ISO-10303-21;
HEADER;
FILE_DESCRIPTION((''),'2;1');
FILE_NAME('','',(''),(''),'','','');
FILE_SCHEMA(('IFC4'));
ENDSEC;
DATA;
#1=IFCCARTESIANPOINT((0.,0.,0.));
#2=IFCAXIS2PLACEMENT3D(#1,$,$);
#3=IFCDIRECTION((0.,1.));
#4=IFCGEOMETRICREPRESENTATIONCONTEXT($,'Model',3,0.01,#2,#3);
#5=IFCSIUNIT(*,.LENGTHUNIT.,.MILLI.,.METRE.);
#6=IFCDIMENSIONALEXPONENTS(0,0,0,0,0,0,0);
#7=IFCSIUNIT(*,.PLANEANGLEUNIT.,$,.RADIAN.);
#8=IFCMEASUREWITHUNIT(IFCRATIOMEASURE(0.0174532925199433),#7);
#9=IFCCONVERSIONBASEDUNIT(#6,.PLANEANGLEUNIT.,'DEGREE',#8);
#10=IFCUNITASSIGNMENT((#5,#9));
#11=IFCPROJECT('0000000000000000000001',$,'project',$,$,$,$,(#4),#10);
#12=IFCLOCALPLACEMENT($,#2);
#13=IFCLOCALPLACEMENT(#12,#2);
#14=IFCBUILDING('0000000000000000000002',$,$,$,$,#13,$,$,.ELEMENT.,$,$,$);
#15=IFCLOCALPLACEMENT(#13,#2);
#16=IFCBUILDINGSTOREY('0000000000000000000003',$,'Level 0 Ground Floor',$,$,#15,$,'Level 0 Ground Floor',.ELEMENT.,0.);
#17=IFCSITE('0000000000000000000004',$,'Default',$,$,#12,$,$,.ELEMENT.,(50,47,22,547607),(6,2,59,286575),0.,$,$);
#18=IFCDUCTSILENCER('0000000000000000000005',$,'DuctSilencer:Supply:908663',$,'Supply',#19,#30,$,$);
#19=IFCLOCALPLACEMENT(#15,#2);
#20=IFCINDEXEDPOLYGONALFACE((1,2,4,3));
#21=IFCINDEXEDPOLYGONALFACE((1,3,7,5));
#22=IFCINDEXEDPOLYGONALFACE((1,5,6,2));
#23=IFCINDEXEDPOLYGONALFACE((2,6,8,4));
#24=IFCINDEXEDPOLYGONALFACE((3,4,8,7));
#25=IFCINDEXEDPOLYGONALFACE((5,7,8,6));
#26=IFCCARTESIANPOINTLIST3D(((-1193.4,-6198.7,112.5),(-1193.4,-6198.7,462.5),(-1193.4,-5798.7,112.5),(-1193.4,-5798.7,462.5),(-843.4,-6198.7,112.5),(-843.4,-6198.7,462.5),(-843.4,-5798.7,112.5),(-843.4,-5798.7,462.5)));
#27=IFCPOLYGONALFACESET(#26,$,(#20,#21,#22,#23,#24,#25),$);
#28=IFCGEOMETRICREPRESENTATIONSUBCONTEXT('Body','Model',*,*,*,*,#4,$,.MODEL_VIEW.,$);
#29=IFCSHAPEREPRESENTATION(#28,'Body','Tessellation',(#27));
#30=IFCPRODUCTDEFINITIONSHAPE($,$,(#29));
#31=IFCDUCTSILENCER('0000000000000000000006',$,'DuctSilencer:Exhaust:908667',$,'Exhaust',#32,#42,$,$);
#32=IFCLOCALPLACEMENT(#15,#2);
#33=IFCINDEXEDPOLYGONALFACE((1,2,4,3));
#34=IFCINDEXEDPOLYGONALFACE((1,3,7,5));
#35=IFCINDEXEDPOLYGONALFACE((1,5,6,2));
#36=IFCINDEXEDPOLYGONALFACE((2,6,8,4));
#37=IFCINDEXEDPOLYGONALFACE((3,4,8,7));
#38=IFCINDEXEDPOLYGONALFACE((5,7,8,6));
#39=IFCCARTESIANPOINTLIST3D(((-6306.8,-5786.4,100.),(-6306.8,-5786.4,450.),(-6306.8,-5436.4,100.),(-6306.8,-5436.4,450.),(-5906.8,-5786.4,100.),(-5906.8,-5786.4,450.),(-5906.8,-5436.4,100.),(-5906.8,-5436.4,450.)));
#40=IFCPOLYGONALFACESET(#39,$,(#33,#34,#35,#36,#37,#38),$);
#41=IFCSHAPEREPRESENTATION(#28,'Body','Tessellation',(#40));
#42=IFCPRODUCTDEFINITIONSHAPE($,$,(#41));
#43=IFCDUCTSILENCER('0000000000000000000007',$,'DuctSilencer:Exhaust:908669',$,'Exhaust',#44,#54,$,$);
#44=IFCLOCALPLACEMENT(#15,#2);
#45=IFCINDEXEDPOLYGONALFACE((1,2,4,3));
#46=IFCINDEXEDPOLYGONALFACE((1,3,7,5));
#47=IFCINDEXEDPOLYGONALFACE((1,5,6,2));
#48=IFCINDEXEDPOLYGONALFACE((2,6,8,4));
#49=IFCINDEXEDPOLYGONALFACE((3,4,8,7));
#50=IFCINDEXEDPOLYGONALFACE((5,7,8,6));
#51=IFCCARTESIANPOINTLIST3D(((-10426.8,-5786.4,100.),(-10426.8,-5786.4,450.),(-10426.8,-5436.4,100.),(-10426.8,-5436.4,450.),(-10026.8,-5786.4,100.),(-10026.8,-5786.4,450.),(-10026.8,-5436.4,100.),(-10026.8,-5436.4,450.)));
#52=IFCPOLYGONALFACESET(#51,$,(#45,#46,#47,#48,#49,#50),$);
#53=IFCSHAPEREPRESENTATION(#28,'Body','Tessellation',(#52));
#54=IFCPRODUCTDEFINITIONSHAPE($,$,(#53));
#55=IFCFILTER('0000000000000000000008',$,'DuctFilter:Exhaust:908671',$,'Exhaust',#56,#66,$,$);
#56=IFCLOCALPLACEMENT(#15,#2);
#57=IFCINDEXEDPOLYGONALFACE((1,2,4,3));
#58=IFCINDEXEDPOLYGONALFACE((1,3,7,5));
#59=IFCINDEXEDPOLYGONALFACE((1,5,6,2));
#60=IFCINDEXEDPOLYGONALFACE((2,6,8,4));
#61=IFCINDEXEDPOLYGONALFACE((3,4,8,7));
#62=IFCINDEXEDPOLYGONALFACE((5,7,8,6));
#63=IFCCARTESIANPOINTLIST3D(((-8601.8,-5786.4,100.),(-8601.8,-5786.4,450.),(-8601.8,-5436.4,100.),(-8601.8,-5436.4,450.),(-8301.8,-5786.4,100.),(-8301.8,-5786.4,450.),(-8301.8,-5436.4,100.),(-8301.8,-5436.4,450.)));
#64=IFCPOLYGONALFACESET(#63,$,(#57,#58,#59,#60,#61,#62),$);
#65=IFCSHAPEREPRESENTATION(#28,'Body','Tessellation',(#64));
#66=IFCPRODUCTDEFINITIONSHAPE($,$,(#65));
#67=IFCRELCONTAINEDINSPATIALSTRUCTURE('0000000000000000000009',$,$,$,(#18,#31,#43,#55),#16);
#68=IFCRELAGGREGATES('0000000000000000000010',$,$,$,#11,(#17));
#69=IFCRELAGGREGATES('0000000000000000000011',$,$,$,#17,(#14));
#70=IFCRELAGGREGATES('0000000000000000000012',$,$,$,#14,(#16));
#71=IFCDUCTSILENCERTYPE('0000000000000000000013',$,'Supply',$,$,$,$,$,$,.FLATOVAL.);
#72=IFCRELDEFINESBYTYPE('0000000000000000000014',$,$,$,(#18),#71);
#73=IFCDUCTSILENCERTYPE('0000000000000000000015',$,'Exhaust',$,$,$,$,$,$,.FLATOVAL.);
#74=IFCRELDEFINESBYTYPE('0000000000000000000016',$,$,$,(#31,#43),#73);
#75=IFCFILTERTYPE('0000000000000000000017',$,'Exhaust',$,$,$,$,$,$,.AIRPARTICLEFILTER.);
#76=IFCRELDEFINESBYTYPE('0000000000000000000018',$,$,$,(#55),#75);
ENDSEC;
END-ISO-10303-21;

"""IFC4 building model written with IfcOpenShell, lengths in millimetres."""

from ifc_helpers import new_model, entity, si_unit, converted_unit, direction, frame, frame_2d, origin, origin_2d_with_axis, place, context, subcontext, project, spatial, rectangle, extrude, source, transform, mapped, type_object, type_shapes, element, save


model = new_model("IFC4")

# Units and contexts
model_context = context("Model", 3, precision=0.01, world=origin(), true_north=direction((0.0, 1.0)))
body_context = subcontext(model_context, "Body", "Model", "MODEL_VIEW")
ifc_project = project(units=[si_unit("LENGTHUNIT", "METRE", prefix="MILLI"), converted_unit("PLANEANGLEUNIT", "DEGREE", entity("IfcRatioMeasure", 0.0174532925199433), si_unit("PLANEANGLEUNIT", "RADIAN"), dimensions=[0, 0, 0, 0, 0, 0, 0])], contexts=[model_context])

# Site, building, storey
site_placement = place(None, origin())
site = spatial("IfcSite", under=ifc_project, at=site_placement, Name="Default", CompositionType="ELEMENT", RefLatitude=(50, 47, 22, 547607), RefLongitude=(6, 2, 59, 286575), RefElevation=0.0)
building_placement = place(site_placement, origin())
building = spatial("IfcBuilding", under=site, at=building_placement, CompositionType="ELEMENT")
storey_placement = place(building_placement, origin())
storey = spatial("IfcBuildingStorey", under=building, at=storey_placement, Name="Level 0 Ground Floor", LongName="Level 0 Ground Floor", CompositionType="ELEMENT", Elevation=0.0)

# Duct silencers
duct_silencer_type_1 = type_object("IfcDuctSilencerType", Name="Supply", PredefinedType="FLATOVAL")
shared_shape_1 = source(origin(), body_context, "Body", "SweptSolid", [
    extrude(rectangle(XDim=400.0, YDim=350.0, at=frame_2d((0.0, 0.0), x_axis=(1.0, 0.0))), frame((0.0, 0.0, -175.0), z_axis=(0.0, 0.0, 1.0), x_axis=(-1.0, 0.0, 0.0)), (0.0, 0.0, 1.0), 350.0),
])
type_shapes(duct_silencer_type_1, [shared_shape_1])
duct_silencer_1_placement = place(storey_placement, frame((-1018.4, -5998.7, 287.5), z_axis=(0.0, 0.0, 1.0), x_axis=(0.0, -1.0, 0.0)))
element("IfcDuctSilencer", 1, at=duct_silencer_1_placement, inside=storey, type_object=duct_silencer_type_1, Name="DuctSilencer:Supply:908663", ObjectType="Supply", context=body_context, shape_type="MappedRepresentation", body=[
    mapped(shared_shape_1, transform((0.0, 0.0, 0.0), scale=1.0)),
])
duct_silencer_type_2 = type_object("IfcDuctSilencerType", Name="Exhaust", PredefinedType="FLATOVAL")
shared_shape_2 = source(origin(), body_context, "Body", "SweptSolid", [
    extrude(rectangle(XDim=400.0, YDim=350.0, at=frame_2d((0.0, 0.0), x_axis=(1.0, 0.0))), frame((0.0, 0.0, -175.0), z_axis=(0.0, 0.0, 1.0), x_axis=(-1.0, 0.0, 0.0)), (0.0, 0.0, 1.0), 350.0),
])
type_shapes(duct_silencer_type_2, [shared_shape_2])
duct_silencer_2_placement = place(storey_placement, frame((-6106.8, -5611.4, 275.0)))
element("IfcDuctSilencer", 2, at=duct_silencer_2_placement, inside=storey, type_object=duct_silencer_type_2, Name="DuctSilencer:Exhaust:908667", ObjectType="Exhaust", context=body_context, shape_type="MappedRepresentation", body=[
    mapped(shared_shape_2, transform((0.0, 0.0, 0.0), scale=1.0)),
])
duct_silencer_3_placement = place(storey_placement, frame((-10226.8, -5611.4, 275.0), z_axis=(0.0, 0.0, 1.0), x_axis=(-1.0, 0.0, 0.0)))
element("IfcDuctSilencer", 3, at=duct_silencer_3_placement, inside=storey, type_object=duct_silencer_type_2, Name="DuctSilencer:Exhaust:908669", ObjectType="Exhaust", context=body_context, shape_type="MappedRepresentation", body=[
    mapped(shared_shape_2, transform((0.0, 0.0, 0.0), scale=1.0)),
])

# Filter
filter_type_1 = type_object("IfcFilterType", Name="Exhaust", PredefinedType="AIRPARTICLEFILTER")
shared_shape_3 = source(origin(), body_context, "Body", "SweptSolid", [
    extrude(rectangle(XDim=300.0, YDim=350.0, at=origin_2d_with_axis()), frame((0.0, 0.0, -175.0), z_axis=(0.0, 0.0, 1.0), x_axis=(-1.0, 0.0, 0.0)), (0.0, 0.0, 1.0), 350.0),
])
type_shapes(filter_type_1, [shared_shape_3])
ifc_filter_placement = place(storey_placement, frame((-8451.8, -5611.4, 275.0), z_axis=(0.0, 0.0, 1.0), x_axis=(-1.0, 0.0, 0.0)))
element("IfcFilter", 4, at=ifc_filter_placement, inside=storey, type_object=filter_type_1, Name="DuctFilter:Exhaust:908671", ObjectType="Exhaust", context=body_context, shape_type="MappedRepresentation", body=[
    mapped(shared_shape_3, transform((0.0, 0.0, 0.0), scale=1.0)),
])

save(model, "model.ifc")
